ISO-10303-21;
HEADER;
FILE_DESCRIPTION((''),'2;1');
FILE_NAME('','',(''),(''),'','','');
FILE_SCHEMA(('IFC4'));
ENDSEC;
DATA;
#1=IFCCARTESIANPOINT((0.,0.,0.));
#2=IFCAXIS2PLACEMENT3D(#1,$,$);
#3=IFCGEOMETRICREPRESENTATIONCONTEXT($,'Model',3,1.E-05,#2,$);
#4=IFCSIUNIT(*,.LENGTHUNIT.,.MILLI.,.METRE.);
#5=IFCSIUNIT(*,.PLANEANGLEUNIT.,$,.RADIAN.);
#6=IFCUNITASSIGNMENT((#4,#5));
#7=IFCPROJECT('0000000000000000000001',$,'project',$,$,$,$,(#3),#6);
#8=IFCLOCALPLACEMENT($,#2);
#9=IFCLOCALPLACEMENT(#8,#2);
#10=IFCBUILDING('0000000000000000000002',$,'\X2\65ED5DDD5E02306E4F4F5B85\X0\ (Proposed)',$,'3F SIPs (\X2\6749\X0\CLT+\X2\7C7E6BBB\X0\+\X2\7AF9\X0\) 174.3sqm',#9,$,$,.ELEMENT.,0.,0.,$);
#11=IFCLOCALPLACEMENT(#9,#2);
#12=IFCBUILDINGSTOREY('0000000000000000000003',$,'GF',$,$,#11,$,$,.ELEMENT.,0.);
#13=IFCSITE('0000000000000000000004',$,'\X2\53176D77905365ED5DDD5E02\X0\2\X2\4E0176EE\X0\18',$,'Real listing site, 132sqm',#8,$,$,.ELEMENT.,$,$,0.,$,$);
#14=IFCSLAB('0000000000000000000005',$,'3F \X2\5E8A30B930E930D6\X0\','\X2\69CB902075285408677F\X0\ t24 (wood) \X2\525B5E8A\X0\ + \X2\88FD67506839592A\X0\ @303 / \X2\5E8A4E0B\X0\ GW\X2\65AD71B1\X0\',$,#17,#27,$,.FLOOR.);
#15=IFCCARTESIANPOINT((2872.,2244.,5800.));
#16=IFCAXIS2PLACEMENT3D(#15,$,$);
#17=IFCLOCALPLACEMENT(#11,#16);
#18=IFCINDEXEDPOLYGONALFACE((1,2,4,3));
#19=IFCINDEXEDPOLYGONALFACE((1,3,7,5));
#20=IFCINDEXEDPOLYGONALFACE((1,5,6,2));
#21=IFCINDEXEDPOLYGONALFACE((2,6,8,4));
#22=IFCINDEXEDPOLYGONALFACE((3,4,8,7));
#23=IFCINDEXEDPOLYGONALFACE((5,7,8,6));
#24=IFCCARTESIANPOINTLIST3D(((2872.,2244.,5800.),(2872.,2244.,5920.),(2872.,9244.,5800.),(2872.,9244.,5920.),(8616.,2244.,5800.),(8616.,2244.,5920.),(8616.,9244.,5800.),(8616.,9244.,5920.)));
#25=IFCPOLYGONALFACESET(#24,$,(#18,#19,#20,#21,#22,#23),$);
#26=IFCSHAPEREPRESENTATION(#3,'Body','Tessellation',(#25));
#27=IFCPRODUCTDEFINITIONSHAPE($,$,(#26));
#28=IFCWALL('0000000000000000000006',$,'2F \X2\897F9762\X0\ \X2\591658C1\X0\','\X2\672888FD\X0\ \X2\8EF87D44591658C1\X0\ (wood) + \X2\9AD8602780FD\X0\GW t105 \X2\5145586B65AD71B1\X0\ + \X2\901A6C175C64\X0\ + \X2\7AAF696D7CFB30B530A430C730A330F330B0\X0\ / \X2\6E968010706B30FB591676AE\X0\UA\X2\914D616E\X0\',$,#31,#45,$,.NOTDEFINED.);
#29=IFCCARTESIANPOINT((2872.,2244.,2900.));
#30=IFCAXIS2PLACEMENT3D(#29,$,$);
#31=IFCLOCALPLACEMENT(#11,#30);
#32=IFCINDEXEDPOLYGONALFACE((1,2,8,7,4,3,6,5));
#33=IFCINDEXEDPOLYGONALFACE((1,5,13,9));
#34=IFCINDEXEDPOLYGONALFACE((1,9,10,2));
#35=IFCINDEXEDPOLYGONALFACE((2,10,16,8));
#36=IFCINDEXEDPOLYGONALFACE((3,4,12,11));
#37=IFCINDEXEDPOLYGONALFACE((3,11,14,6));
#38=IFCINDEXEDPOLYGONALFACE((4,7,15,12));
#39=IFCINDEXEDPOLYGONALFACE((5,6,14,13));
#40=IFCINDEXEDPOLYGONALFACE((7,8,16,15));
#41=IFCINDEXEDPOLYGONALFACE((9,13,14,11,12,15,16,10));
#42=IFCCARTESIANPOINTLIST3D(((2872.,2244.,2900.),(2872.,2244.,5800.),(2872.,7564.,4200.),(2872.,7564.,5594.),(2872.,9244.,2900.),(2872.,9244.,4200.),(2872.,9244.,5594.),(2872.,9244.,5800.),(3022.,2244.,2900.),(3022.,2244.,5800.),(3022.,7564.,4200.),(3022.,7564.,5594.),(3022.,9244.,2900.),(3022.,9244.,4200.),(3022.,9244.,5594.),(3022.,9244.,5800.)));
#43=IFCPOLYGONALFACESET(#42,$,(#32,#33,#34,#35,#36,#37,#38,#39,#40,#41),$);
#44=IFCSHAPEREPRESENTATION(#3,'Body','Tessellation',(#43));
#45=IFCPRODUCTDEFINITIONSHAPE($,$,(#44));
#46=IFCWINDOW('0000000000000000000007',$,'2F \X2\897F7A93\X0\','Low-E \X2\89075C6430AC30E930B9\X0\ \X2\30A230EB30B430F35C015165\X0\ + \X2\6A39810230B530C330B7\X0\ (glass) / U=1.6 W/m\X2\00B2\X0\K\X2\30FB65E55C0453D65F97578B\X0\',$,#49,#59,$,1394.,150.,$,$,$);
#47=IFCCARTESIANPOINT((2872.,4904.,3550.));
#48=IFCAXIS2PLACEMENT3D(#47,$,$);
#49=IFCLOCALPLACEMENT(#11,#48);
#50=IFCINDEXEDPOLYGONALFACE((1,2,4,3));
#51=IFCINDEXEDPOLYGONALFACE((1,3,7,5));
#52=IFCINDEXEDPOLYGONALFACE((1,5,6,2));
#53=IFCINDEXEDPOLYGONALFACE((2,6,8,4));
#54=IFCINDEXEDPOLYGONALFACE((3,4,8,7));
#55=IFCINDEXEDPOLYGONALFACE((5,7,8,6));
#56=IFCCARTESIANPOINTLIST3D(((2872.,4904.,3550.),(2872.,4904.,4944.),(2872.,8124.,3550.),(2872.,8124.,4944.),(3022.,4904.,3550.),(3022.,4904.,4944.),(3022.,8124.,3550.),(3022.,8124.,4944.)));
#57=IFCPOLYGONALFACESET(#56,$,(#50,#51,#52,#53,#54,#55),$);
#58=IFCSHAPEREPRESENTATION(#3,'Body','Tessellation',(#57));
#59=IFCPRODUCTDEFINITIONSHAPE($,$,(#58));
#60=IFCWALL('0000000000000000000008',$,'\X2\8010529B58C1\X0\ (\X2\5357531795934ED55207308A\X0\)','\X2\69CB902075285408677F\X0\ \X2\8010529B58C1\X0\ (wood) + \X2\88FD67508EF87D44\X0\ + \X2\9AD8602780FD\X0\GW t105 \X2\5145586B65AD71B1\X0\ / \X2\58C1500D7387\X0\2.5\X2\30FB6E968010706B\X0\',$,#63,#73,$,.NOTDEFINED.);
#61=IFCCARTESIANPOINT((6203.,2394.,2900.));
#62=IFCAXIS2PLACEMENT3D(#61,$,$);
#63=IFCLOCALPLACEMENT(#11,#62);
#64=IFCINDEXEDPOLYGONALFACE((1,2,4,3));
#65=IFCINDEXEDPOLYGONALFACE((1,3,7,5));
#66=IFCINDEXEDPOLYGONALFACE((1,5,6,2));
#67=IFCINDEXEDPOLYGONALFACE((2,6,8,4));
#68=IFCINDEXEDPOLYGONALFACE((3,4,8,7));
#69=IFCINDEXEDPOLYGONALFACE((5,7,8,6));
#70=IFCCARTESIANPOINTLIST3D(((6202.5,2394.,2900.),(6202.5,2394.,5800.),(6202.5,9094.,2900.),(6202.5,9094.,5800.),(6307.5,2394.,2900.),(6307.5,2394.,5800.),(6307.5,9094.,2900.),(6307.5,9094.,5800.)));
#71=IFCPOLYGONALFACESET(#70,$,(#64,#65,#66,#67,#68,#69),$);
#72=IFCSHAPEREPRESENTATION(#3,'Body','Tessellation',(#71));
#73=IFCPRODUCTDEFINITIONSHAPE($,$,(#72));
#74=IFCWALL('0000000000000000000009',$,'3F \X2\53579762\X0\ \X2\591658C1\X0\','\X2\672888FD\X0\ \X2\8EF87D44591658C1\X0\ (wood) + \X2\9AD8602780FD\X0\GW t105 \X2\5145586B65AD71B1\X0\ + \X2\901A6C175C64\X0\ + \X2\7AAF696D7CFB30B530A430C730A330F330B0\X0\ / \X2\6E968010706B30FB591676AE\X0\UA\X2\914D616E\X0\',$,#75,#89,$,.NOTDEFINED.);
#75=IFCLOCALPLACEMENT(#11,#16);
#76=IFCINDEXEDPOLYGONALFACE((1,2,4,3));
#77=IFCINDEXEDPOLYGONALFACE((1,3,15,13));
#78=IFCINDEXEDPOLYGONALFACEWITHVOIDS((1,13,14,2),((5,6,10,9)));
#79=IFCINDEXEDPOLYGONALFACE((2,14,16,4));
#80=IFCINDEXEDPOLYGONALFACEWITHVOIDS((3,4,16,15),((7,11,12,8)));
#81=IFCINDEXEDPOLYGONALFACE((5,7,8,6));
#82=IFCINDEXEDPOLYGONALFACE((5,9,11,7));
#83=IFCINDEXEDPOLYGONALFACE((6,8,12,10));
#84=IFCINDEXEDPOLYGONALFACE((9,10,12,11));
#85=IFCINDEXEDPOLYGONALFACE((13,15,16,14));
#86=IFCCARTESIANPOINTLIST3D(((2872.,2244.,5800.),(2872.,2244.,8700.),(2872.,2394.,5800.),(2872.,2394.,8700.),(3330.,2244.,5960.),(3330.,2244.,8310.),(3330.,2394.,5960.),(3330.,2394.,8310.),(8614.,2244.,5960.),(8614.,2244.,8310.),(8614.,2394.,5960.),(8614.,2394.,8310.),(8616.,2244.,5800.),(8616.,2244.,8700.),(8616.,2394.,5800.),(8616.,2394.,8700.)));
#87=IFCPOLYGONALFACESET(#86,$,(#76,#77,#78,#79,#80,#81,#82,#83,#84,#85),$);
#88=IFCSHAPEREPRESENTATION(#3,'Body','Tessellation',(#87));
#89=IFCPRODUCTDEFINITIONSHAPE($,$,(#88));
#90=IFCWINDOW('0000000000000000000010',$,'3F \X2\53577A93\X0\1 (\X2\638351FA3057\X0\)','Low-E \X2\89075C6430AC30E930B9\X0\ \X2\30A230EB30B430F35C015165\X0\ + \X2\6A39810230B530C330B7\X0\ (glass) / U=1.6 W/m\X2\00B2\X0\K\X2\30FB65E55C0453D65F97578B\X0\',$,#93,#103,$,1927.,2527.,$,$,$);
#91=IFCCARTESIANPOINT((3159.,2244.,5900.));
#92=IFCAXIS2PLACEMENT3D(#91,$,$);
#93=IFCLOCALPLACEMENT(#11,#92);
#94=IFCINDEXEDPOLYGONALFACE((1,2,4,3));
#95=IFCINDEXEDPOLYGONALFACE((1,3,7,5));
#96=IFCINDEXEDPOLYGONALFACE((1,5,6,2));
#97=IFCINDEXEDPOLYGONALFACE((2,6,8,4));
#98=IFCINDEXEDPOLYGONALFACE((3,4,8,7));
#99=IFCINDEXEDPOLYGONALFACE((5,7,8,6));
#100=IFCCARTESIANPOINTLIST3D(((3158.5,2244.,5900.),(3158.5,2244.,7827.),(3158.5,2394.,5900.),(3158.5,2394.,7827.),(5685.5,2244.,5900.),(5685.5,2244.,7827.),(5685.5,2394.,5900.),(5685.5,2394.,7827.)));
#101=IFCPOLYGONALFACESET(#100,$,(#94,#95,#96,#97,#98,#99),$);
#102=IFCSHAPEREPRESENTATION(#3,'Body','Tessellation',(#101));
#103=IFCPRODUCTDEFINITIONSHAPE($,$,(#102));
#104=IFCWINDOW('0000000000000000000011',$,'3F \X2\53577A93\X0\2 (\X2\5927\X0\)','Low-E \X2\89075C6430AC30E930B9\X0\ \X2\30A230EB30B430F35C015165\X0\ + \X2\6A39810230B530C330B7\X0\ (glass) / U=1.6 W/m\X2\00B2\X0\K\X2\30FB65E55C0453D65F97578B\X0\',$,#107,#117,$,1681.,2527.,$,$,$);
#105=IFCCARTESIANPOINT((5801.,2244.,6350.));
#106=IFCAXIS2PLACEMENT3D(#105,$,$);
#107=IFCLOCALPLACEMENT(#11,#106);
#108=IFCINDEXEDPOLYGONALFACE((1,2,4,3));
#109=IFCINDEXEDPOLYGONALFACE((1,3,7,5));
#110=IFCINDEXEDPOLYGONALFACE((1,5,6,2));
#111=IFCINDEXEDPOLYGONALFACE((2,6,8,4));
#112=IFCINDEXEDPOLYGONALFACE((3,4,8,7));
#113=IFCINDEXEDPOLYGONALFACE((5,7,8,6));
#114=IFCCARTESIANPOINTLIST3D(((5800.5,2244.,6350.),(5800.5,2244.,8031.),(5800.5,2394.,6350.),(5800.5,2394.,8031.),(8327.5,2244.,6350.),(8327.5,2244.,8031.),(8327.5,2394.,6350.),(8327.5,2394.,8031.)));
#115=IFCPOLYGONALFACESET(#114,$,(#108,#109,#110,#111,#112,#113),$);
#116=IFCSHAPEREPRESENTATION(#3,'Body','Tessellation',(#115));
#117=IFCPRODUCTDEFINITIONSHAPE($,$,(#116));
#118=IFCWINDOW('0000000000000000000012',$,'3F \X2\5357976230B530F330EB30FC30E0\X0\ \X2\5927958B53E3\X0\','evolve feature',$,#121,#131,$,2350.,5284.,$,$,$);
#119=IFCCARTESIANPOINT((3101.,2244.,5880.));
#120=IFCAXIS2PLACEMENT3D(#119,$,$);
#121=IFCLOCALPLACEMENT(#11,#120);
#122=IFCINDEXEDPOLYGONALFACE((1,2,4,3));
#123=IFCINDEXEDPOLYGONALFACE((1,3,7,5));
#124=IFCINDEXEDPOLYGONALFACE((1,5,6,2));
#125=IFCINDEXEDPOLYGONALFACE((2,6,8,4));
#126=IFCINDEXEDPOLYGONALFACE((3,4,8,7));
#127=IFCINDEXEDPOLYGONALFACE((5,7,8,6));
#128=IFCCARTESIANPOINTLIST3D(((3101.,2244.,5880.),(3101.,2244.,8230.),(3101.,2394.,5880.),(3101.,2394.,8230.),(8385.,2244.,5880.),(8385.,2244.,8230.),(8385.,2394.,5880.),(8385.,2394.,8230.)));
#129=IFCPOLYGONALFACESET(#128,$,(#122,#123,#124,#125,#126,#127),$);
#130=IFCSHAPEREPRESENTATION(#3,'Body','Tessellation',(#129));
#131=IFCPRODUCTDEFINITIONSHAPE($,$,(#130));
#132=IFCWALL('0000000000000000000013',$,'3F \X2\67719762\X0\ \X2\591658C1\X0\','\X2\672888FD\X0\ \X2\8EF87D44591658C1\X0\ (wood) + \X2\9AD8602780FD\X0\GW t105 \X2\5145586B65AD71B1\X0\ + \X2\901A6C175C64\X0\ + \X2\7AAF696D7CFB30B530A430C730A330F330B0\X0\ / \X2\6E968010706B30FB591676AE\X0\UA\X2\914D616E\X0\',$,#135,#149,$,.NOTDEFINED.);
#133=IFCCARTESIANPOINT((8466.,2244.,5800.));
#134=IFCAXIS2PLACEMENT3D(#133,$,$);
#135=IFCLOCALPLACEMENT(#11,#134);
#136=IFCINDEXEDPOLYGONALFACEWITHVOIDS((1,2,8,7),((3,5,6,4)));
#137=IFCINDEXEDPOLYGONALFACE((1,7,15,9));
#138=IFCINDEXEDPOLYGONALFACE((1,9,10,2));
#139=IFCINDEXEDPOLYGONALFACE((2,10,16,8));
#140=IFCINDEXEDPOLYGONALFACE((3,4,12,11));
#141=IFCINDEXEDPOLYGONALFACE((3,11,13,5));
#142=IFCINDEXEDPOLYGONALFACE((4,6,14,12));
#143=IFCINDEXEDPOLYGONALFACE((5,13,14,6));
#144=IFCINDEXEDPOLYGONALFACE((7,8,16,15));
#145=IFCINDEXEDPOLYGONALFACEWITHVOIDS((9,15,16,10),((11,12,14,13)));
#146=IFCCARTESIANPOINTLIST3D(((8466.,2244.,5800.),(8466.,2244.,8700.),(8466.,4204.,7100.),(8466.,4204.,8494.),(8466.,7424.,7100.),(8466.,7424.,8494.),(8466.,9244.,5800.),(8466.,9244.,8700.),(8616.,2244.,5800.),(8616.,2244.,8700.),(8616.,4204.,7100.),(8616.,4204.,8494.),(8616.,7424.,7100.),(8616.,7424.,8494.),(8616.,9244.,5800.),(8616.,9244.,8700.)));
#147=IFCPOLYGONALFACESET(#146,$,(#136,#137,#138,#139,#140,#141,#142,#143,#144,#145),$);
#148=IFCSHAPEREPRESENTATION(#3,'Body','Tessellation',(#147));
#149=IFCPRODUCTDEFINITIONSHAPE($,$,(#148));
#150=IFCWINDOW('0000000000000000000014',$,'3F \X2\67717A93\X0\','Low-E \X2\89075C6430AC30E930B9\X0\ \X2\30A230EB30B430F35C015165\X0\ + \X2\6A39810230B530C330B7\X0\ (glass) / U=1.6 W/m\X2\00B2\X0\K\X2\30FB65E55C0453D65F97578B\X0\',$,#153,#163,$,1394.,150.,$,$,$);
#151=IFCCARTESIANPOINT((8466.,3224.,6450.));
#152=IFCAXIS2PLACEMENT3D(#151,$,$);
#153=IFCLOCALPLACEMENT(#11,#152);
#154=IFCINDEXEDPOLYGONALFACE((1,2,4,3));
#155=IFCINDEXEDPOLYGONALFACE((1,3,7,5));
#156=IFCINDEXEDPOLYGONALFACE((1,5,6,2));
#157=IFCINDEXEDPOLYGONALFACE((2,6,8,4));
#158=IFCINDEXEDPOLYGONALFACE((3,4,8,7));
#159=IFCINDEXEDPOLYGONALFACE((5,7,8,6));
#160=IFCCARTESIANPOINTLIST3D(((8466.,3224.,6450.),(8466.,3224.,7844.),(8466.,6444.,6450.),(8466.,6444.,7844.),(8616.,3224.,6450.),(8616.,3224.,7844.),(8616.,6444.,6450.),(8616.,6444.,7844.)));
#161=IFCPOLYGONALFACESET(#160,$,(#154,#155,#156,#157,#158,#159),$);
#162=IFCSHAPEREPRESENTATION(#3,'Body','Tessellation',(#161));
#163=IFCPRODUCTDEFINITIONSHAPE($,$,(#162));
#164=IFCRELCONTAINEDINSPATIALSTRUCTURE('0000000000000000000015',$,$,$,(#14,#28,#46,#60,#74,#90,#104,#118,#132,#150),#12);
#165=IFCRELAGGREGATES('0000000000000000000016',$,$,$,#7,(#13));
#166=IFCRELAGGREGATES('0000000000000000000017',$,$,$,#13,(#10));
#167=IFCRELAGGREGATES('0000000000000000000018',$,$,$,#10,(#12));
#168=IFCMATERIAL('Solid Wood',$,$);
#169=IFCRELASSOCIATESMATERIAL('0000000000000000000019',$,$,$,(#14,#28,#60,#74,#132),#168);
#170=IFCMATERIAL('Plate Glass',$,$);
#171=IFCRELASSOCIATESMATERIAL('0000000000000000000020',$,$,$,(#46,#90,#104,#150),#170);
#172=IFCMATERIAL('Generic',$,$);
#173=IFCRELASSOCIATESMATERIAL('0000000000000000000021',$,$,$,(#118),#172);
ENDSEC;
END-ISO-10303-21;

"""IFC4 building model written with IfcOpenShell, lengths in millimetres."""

from ifc_helpers import new_model, si_unit, frame, frame_2d, origin, place, context, project, spatial, rectangle, extrude, material, element, fill, save


model = new_model("IFC4")

# Units and contexts
model_context = context("Model", 3, precision=1e-05, world=origin())
ifc_project = project(units=[si_unit("LENGTHUNIT", "METRE", prefix="MILLI"), si_unit("PLANEANGLEUNIT", "RADIAN")], contexts=[model_context])

# Site, building, storey
site_placement = place(None, origin())
site = spatial("IfcSite", under=ifc_project, at=site_placement, Name="北海道旭川市2丁目18", ObjectType="Real listing site, 132sqm", CompositionType="ELEMENT", RefElevation=0.0)
building_placement = place(site_placement, origin())
building = spatial("IfcBuilding", under=site, at=building_placement, Name="旭川市の住宅 (Proposed)", ObjectType="3F SIPs (杉CLT+籾殻+竹) 174.3sqm", CompositionType="ELEMENT", ElevationOfRefHeight=0.0, ElevationOfTerrain=0.0)
storey_placement = place(building_placement, origin())
storey = spatial("IfcBuildingStorey", under=building, at=storey_placement, Name="GF", CompositionType="ELEMENT", Elevation=0.0)

# Slab
ifc_material_1 = material(Name="Solid Wood")
slab_placement = place(storey_placement, frame((2872.0, 2244.0, 5800.0)))
element("IfcSlab", 1, at=slab_placement, inside=storey, material=ifc_material_1, Name="3F 床スラブ", Description="構造用合板 t24 (wood) 剛床 + 製材根太 @303 / 床下 GW断熱", PredefinedType="FLOOR", context=model_context, shape_type="SweptSolid", body=[
    extrude(rectangle(XDim=5744.0, YDim=7000.0, at=frame_2d((2872.0, 3500.0))), frame((2872.0, 2244.0, 5800.0)), (0.0, 0.0, 1.0), 120.0),
])

# Wall, opening, window
wall_1_placement = place(storey_placement, frame((2872.0, 2244.0, 2900.0)))
wall_1 = element("IfcWall", 2, at=wall_1_placement, inside=storey, material=ifc_material_1, Name="2F 西面 外壁", Description="木製 軸組外壁 (wood) + 高性能GW t105 充填断熱 + 通気層 + 窯業系サイディング / 準耐火・外皮UA配慮", PredefinedType="NOTDEFINED", context=model_context, shape_type="SweptSolid", body=[
    extrude(rectangle(XDim=150.0, YDim=7000.0, at=frame_2d((75.0, 3500.0))), frame((2872.0, 2244.0, 2900.0)), (0.0, 0.0, 1.0), 2900.0),
])
opening_1_placement = place(storey_placement, frame((2872.0, 4904.0, 3550.0)))
opening_1 = element("IfcOpeningElement", 3, at=opening_1_placement, cuts=wall_1, PredefinedType="NOTDEFINED", context=model_context, shape_type="SweptSolid", body=[
    extrude(rectangle(XDim=150.0, YDim=3220.0, at=frame_2d((75.0, 1610.0))), frame((2872.0, 4904.0, 3550.0)), (0.0, 0.0, 1.0), 1394.0),
])
ifc_material_2 = material(Name="Plate Glass")
window_1_placement = place(storey_placement, frame((2872.0, 4904.0, 3550.0)))
window_1 = element("IfcWindow", 4, at=window_1_placement, inside=storey, material=ifc_material_2, Name="2F 西窓", Description="Low-E 複層ガラス アルゴン封入 + 樹脂サッシ (glass) / U=1.6 W/m²K・日射取得型", OverallHeight=1394.0, OverallWidth=150.0, context=model_context, shape_type="SweptSolid", body=[
    extrude(rectangle(XDim=150.0, YDim=3220.0, at=frame_2d((75.0, 1610.0))), frame((2872.0, 4904.0, 3550.0)), (0.0, 0.0, 1.0), 1394.0),
])
fill(opening_1, window_1)

# Wall
wall_2_placement = place(storey_placement, frame((6203.0, 2394.0, 2900.0)))
element("IfcWall", 5, at=wall_2_placement, inside=storey, material=ifc_material_1, Name="耐力壁 (南北間仕切り)", Description="構造用合板 耐力壁 (wood) + 製材軸組 + 高性能GW t105 充填断熱 / 壁倍率2.5・準耐火", PredefinedType="NOTDEFINED", context=model_context, shape_type="SweptSolid", body=[
    extrude(rectangle(XDim=105.0, YDim=6700.0, at=frame_2d((52.0, 3350.0))), frame((6203.0, 2394.0, 2900.0)), (0.0, 0.0, 1.0), 2900.0),
])

# Wall, openings, windows
wall_3_placement = place(storey_placement, frame((2872.0, 2244.0, 5800.0)))
wall_3 = element("IfcWall", 6, at=wall_3_placement, inside=storey, material=ifc_material_1, Name="3F 南面 外壁", Description="木製 軸組外壁 (wood) + 高性能GW t105 充填断熱 + 通気層 + 窯業系サイディング / 準耐火・外皮UA配慮", PredefinedType="NOTDEFINED", context=model_context, shape_type="SweptSolid", body=[
    extrude(rectangle(XDim=5744.0, YDim=150.0, at=frame_2d((2872.0, 75.0))), frame((2872.0, 2244.0, 5800.0)), (0.0, 0.0, 1.0), 2900.0),
])
opening_2_placement = place(storey_placement, frame((3159.0, 2244.0, 5900.0)))
opening_2 = element("IfcOpeningElement", 7, at=opening_2_placement, cuts=wall_3, PredefinedType="NOTDEFINED", context=model_context, shape_type="SweptSolid", body=[
    extrude(rectangle(XDim=2527.0, YDim=150.0, at=frame_2d((1263.0, 75.0))), frame((3159.0, 2244.0, 5900.0)), (0.0, 0.0, 1.0), 1927.0),
])
opening_3_placement = place(storey_placement, frame((5801.0, 2244.0, 6350.0)))
opening_3 = element("IfcOpeningElement", 8, at=opening_3_placement, cuts=wall_3, PredefinedType="NOTDEFINED", context=model_context, shape_type="SweptSolid", body=[
    extrude(rectangle(XDim=2527.0, YDim=150.0, at=frame_2d((1263.0, 75.0))), frame((5801.0, 2244.0, 6350.0)), (0.0, 0.0, 1.0), 1681.0),
])
opening_4_placement = place(storey_placement, frame((3101.0, 2244.0, 5880.0)))
opening_4 = element("IfcOpeningElement", 9, at=opening_4_placement, cuts=wall_3, PredefinedType="NOTDEFINED", context=model_context, shape_type="SweptSolid", body=[
    extrude(rectangle(XDim=5284.0, YDim=150.0, at=frame_2d((2642.0, 75.0))), frame((3101.0, 2244.0, 5880.0)), (0.0, 0.0, 1.0), 2350.0),
])
window_2_placement = place(storey_placement, frame((3159.0, 2244.0, 5900.0)))
window_2 = element("IfcWindow", 10, at=window_2_placement, inside=storey, material=ifc_material_2, Name="3F 南窓1 (掃出し)", Description="Low-E 複層ガラス アルゴン封入 + 樹脂サッシ (glass) / U=1.6 W/m²K・日射取得型", OverallHeight=1927.0, OverallWidth=2527.0, context=model_context, shape_type="SweptSolid", body=[
    extrude(rectangle(XDim=2527.0, YDim=150.0, at=frame_2d((1263.0, 75.0))), frame((3159.0, 2244.0, 5900.0)), (0.0, 0.0, 1.0), 1927.0),
])
fill(opening_2, window_2)
window_3_placement = place(storey_placement, frame((5801.0, 2244.0, 6350.0)))
window_3 = element("IfcWindow", 11, at=window_3_placement, inside=storey, material=ifc_material_2, Name="3F 南窓2 (大)", Description="Low-E 複層ガラス アルゴン封入 + 樹脂サッシ (glass) / U=1.6 W/m²K・日射取得型", OverallHeight=1681.0, OverallWidth=2527.0, context=model_context, shape_type="SweptSolid", body=[
    extrude(rectangle(XDim=2527.0, YDim=150.0, at=frame_2d((1263.0, 75.0))), frame((5801.0, 2244.0, 6350.0)), (0.0, 0.0, 1.0), 1681.0),
])
fill(opening_3, window_3)
ifc_material_3 = material(Name="Generic")
window_4_placement = place(storey_placement, frame((3101.0, 2244.0, 5880.0)))
window_4 = element("IfcWindow", 12, at=window_4_placement, inside=storey, material=ifc_material_3, Name="3F 南面サンルーム 大開口", Description="evolve feature", OverallHeight=2350.0, OverallWidth=5284.0, context=model_context, shape_type="SweptSolid", body=[
    extrude(rectangle(XDim=5284.0, YDim=150.0, at=frame_2d((2642.0, 75.0))), frame((3101.0, 2244.0, 5880.0)), (0.0, 0.0, 1.0), 2350.0),
])
fill(opening_4, window_4)

# Wall, opening, window
wall_4_placement = place(storey_placement, frame((8466.0, 2244.0, 5800.0)))
wall_4 = element("IfcWall", 13, at=wall_4_placement, inside=storey, material=ifc_material_1, Name="3F 東面 外壁", Description="木製 軸組外壁 (wood) + 高性能GW t105 充填断熱 + 通気層 + 窯業系サイディング / 準耐火・外皮UA配慮", PredefinedType="NOTDEFINED", context=model_context, shape_type="SweptSolid", body=[
    extrude(rectangle(XDim=150.0, YDim=7000.0, at=frame_2d((75.0, 3500.0))), frame((8466.0, 2244.0, 5800.0)), (0.0, 0.0, 1.0), 2900.0),
])
opening_5_placement = place(storey_placement, frame((8466.0, 3224.0, 6450.0)))
opening_5 = element("IfcOpeningElement", 14, at=opening_5_placement, cuts=wall_4, PredefinedType="NOTDEFINED", context=model_context, shape_type="SweptSolid", body=[
    extrude(rectangle(XDim=150.0, YDim=3220.0, at=frame_2d((75.0, 1610.0))), frame((8466.0, 3224.0, 6450.0)), (0.0, 0.0, 1.0), 1394.0),
])
window_5_placement = place(storey_placement, frame((8466.0, 3224.0, 6450.0)))
window_5 = element("IfcWindow", 15, at=window_5_placement, inside=storey, material=ifc_material_2, Name="3F 東窓", Description="Low-E 複層ガラス アルゴン封入 + 樹脂サッシ (glass) / U=1.6 W/m²K・日射取得型", OverallHeight=1394.0, OverallWidth=150.0, context=model_context, shape_type="SweptSolid", body=[
    extrude(rectangle(XDim=150.0, YDim=3220.0, at=frame_2d((75.0, 1610.0))), frame((8466.0, 3224.0, 6450.0)), (0.0, 0.0, 1.0), 1394.0),
])
fill(opening_5, window_5)

save(model, "model.ifc")
